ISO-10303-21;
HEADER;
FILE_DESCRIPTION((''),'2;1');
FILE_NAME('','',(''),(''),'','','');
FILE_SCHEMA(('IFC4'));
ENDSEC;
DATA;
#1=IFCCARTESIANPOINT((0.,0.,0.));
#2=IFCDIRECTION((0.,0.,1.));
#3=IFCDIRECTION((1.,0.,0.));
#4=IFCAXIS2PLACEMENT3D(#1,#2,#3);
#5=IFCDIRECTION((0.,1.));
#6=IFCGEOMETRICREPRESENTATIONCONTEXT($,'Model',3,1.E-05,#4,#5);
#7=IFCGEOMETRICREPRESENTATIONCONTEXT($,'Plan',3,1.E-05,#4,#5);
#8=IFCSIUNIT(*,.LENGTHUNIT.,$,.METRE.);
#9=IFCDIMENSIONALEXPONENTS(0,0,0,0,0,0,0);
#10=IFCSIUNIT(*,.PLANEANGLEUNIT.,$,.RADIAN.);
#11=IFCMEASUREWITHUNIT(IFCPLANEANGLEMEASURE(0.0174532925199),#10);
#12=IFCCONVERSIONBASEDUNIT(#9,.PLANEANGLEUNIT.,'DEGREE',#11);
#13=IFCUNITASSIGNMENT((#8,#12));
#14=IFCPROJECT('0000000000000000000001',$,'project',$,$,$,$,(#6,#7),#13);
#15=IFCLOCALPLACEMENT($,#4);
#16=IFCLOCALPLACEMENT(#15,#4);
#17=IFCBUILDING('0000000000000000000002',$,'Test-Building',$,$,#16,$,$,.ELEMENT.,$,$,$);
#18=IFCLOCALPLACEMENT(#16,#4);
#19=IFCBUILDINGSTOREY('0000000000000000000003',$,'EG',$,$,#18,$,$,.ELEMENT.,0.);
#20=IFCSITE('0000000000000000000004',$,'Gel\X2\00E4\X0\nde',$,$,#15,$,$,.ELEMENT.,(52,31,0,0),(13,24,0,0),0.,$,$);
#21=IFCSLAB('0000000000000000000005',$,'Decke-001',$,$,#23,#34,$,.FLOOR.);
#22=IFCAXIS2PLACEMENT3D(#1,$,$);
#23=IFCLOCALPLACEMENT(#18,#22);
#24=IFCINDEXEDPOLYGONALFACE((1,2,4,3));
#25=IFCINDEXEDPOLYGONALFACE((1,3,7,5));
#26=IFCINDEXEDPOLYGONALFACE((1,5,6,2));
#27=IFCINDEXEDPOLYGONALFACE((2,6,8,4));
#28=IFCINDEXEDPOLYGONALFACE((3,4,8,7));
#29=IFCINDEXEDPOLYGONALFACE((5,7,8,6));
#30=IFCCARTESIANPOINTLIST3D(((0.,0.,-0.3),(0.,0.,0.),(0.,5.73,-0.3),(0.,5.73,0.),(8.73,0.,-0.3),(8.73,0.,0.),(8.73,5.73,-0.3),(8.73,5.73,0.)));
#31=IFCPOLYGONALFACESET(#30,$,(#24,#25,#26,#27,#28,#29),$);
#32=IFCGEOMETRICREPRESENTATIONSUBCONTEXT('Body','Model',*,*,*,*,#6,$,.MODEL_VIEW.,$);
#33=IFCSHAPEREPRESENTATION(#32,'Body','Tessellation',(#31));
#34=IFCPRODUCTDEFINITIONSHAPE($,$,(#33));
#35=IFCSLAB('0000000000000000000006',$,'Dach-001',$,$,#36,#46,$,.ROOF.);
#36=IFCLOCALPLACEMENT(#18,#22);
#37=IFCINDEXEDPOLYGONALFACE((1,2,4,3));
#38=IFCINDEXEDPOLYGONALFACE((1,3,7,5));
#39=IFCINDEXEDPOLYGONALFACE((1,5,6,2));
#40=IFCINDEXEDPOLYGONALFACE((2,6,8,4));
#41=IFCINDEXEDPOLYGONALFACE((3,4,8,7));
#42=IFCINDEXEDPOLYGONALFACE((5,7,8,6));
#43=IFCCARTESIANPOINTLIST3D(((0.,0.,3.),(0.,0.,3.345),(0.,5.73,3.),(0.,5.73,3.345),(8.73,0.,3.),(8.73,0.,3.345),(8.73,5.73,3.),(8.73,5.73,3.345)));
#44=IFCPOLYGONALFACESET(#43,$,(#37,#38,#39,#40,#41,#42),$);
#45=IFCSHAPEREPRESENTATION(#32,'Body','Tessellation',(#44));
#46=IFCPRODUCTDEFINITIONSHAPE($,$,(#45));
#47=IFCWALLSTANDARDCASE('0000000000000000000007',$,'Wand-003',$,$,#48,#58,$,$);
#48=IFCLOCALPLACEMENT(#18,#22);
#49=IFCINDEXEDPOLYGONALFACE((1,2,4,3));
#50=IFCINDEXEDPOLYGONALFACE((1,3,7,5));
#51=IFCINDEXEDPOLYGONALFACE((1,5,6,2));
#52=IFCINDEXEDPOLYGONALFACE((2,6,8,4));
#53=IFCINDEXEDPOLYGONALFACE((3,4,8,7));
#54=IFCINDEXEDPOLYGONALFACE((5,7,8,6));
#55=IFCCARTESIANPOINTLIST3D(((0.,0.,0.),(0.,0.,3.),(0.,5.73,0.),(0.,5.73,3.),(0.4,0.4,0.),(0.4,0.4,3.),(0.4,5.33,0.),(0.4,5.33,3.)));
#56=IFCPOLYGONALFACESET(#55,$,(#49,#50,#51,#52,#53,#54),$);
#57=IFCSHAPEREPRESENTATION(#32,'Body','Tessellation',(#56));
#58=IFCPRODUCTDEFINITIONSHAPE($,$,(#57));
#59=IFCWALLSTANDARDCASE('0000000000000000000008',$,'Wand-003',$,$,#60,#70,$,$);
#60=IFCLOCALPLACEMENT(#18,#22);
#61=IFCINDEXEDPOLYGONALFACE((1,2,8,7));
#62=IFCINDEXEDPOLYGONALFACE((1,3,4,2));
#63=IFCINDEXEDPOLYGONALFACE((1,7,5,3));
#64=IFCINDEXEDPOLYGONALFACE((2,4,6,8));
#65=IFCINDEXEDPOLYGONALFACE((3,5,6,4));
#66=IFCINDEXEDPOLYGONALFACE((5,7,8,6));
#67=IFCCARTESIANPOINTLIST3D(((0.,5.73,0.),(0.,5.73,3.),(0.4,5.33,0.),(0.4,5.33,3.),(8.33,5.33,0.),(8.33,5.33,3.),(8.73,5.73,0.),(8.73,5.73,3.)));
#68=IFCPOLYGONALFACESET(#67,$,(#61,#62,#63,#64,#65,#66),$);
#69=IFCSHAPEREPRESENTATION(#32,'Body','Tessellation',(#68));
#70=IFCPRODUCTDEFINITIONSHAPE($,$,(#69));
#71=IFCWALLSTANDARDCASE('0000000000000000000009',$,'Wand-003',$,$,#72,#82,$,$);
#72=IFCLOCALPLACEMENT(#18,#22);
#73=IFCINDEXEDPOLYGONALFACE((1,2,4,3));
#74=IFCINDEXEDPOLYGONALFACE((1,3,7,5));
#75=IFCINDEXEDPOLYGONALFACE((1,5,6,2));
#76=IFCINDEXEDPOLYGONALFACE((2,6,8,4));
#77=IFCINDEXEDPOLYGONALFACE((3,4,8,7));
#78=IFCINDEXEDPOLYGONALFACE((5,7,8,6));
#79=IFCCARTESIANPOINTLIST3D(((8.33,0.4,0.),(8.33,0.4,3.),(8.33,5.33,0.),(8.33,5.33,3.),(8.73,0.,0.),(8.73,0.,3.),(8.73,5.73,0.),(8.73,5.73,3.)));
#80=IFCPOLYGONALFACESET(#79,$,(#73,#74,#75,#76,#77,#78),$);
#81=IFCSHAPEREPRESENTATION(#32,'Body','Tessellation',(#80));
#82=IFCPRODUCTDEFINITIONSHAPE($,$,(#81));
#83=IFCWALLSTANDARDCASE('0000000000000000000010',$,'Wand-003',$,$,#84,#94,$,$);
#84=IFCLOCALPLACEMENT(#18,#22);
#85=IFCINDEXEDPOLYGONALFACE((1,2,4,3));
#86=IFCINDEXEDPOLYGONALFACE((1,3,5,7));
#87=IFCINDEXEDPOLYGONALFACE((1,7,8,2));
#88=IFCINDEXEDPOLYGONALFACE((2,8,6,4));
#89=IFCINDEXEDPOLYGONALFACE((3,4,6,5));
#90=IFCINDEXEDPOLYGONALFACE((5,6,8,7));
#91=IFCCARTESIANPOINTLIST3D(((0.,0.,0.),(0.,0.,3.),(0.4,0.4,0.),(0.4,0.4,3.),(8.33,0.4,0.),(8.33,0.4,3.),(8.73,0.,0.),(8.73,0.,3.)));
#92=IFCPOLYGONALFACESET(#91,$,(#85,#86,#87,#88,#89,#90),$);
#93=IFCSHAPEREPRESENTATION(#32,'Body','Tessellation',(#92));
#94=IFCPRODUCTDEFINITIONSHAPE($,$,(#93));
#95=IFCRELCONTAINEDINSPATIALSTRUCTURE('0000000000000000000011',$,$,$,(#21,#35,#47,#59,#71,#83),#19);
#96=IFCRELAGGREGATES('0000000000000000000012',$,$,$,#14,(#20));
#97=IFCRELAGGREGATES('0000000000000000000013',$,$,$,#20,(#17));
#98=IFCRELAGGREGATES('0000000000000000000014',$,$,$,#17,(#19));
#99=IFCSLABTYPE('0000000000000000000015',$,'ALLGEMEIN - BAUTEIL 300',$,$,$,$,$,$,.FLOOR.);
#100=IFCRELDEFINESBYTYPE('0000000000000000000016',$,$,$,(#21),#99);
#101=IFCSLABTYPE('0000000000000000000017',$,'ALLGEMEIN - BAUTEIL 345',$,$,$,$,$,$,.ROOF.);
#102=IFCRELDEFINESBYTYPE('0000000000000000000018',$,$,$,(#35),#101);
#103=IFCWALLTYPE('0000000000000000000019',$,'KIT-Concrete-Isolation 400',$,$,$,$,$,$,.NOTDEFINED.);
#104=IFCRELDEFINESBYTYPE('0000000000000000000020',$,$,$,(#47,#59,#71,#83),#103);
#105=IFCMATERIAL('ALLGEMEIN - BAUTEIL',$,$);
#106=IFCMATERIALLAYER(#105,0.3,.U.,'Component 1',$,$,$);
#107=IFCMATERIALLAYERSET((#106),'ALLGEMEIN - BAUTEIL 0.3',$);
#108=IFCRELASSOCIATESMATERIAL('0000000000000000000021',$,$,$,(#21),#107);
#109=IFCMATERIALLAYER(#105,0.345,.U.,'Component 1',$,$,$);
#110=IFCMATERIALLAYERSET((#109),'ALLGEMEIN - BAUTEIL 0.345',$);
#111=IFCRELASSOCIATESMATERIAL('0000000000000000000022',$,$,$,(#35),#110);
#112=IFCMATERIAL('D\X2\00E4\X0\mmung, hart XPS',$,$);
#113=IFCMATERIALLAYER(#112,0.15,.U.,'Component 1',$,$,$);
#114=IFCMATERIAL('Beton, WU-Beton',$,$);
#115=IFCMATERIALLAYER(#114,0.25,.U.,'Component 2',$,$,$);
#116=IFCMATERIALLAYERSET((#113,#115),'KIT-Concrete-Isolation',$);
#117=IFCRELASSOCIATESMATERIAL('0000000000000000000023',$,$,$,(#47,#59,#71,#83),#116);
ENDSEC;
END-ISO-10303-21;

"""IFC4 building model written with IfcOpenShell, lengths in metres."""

from ifc_helpers import new_model, entity, si_unit, converted_unit, direction, frame, origin_with_axes, place, context, subcontext, project, spatial, polyline, outline, extrude, material, layer, layer_set, layer_usage, type_object, element, save


model = new_model("IFC4")

# Units and contexts
model_context = context("Model", 3, precision=1e-05, world=origin_with_axes(), true_north=direction((0.0, 1.0)))
plan_context = context("Plan", 3, precision=1e-05, world=origin_with_axes(), true_north=direction((0.0, 1.0)))
body_context = subcontext(model_context, "Body", "Model", "MODEL_VIEW")
ifc_project = project(units=[si_unit("LENGTHUNIT", "METRE"), converted_unit("PLANEANGLEUNIT", "DEGREE", entity("IfcPlaneAngleMeasure", 0.0174532925199), si_unit("PLANEANGLEUNIT", "RADIAN"), dimensions=[0, 0, 0, 0, 0, 0, 0])], contexts=[model_context, plan_context])

# Site, building, storey
site_placement = place(None, origin_with_axes())
site = spatial("IfcSite", under=ifc_project, at=site_placement, Name="Gelände", CompositionType="ELEMENT", RefLatitude=(52, 31, 0, 0), RefLongitude=(13, 24, 0, 0), RefElevation=0.0)
building_placement = place(site_placement, origin_with_axes())
building = spatial("IfcBuilding", under=site, at=building_placement, Name="Test-Building", CompositionType="ELEMENT")
storey_placement = place(building_placement, origin_with_axes())
storey = spatial("IfcBuildingStorey", under=building, at=storey_placement, Name="EG", CompositionType="ELEMENT", Elevation=0.0)

# Slabs
ifc_material_1 = material(Name="ALLGEMEIN - BAUTEIL")
ifc_layer_1 = layer(ifc_material_1, 0.3, ventilated="UNKNOWN", Name="Component 1")
ifc_layer_set_1 = layer_set([ifc_layer_1], Name="ALLGEMEIN - BAUTEIL 0.3")
ifc_layer_usage_1 = layer_usage(ifc_layer_set_1, "AXIS3", "NEGATIVE", 0.3)
slab_type_1 = type_object("IfcSlabType", Name="ALLGEMEIN - BAUTEIL 300", PredefinedType="FLOOR")
slab_1_placement = place(storey_placement, origin_with_axes())
element("IfcSlab", 1, at=slab_1_placement, inside=storey, type_object=slab_type_1, material=ifc_layer_usage_1, Name="Decke-001", PredefinedType="FLOOR", context=body_context, shape_type="SweptSolid", body=[
    extrude(outline(polyline([(0.0, 0.0), (8.73, 0.0), (8.73, 5.73), (0.0, 5.73), (0.0, 0.0)])), frame((0.0, 0.0, -0.3), z_axis=(0.0, 0.0, 1.0), x_axis=(1.0, 0.0, 0.0)), (0.0, 0.0, 1.0), 0.3),
])
ifc_layer_2 = layer(ifc_material_1, 0.345, ventilated="UNKNOWN", Name="Component 1")
ifc_layer_set_2 = layer_set([ifc_layer_2], Name="ALLGEMEIN - BAUTEIL 0.345")
ifc_layer_usage_2 = layer_usage(ifc_layer_set_2, "AXIS3", "NEGATIVE", 0.345)
slab_type_2 = type_object("IfcSlabType", Name="ALLGEMEIN - BAUTEIL 345", PredefinedType="ROOF")
slab_2_placement = place(storey_placement, frame((0.0, 0.0, 3.0), z_axis=(0.0, 0.0, 1.0), x_axis=(1.0, 0.0, 0.0)))
element("IfcSlab", 2, at=slab_2_placement, inside=storey, type_object=slab_type_2, material=ifc_layer_usage_2, Name="Dach-001", PredefinedType="ROOF", context=body_context, shape_type="SweptSolid", body=[
    extrude(outline(polyline([(0.0, 0.0), (8.73, 0.0), (8.73, 5.73), (0.0, 5.73), (0.0, 0.0)])), origin_with_axes(), (0.0, 0.0, 1.0), 0.345),
])

# Walls
ifc_material_2 = material(Name="Dämmung, hart XPS")
ifc_layer_3 = layer(ifc_material_2, 0.15, ventilated="UNKNOWN", Name="Component 1")
ifc_material_3 = material(Name="Beton, WU-Beton")
ifc_layer_4 = layer(ifc_material_3, 0.25, ventilated="UNKNOWN", Name="Component 2")
ifc_layer_set_3 = layer_set([ifc_layer_3, ifc_layer_4], Name="KIT-Concrete-Isolation")
ifc_layer_usage_3 = layer_usage(ifc_layer_set_3, "AXIS2", "NEGATIVE", 0.0)
wall_type = type_object("IfcWallType", Name="KIT-Concrete-Isolation 400", PredefinedType="NOTDEFINED")
wall_1_placement = place(storey_placement, frame((0.0, 0.0, 0.0), z_axis=(0.0, 0.0, 1.0), x_axis=(0.0, 1.0, 0.0)))
element("IfcWallStandardCase", 3, at=wall_1_placement, inside=storey, type_object=wall_type, material=ifc_layer_usage_3, Name="Wand-003", context=body_context, shape_type="SweptSolid", body=[
    extrude(outline(polyline([(0.4, -0.4), (5.33, -0.4), (5.73, 0.0), (0.0, 0.0), (0.4, -0.4)])), origin_with_axes(), (0.0, 0.0, 1.0), 3.0),
])
ifc_layer_usage_4 = layer_usage(ifc_layer_set_3, "AXIS2", "NEGATIVE", 0.0)
wall_2_placement = place(storey_placement, frame((0.0, 5.73, 0.0), z_axis=(0.0, 0.0, 1.0), x_axis=(1.0, 0.0, 0.0)))
element("IfcWallStandardCase", 4, at=wall_2_placement, inside=storey, type_object=wall_type, material=ifc_layer_usage_4, Name="Wand-003", context=body_context, shape_type="SweptSolid", body=[
    extrude(outline(polyline([(0.4, -0.4), (8.33, -0.4), (8.73, 0.0), (0.0, 0.0), (0.4, -0.4)])), origin_with_axes(), (0.0, 0.0, 1.0), 3.0),
])
ifc_layer_usage_5 = layer_usage(ifc_layer_set_3, "AXIS2", "NEGATIVE", 0.0)
wall_3_placement = place(storey_placement, frame((8.73, 5.73, 0.0), z_axis=(0.0, 0.0, 1.0), x_axis=(0.0, -1.0, 0.0)))
element("IfcWallStandardCase", 5, at=wall_3_placement, inside=storey, type_object=wall_type, material=ifc_layer_usage_5, Name="Wand-003", context=body_context, shape_type="SweptSolid", body=[
    extrude(outline(polyline([(0.4, -0.4), (5.33, -0.4), (5.73, 0.0), (0.0, 0.0), (0.4, -0.4)])), origin_with_axes(), (0.0, 0.0, 1.0), 3.0),
])
ifc_layer_usage_6 = layer_usage(ifc_layer_set_3, "AXIS2", "NEGATIVE", 0.0)
wall_4_placement = place(storey_placement, frame((8.73, 0.0, 0.0), z_axis=(0.0, 0.0, 1.0), x_axis=(-1.0, 0.0, 0.0)))
element("IfcWallStandardCase", 6, at=wall_4_placement, inside=storey, type_object=wall_type, material=ifc_layer_usage_6, Name="Wand-003", context=body_context, shape_type="SweptSolid", body=[
    extrude(outline(polyline([(0.4, -0.4), (8.33, -0.4), (8.73, 0.0), (0.0, 0.0), (0.4, -0.4)])), origin_with_axes(), (0.0, 0.0, 1.0), 3.0),
])

save(model, "model.ifc")
